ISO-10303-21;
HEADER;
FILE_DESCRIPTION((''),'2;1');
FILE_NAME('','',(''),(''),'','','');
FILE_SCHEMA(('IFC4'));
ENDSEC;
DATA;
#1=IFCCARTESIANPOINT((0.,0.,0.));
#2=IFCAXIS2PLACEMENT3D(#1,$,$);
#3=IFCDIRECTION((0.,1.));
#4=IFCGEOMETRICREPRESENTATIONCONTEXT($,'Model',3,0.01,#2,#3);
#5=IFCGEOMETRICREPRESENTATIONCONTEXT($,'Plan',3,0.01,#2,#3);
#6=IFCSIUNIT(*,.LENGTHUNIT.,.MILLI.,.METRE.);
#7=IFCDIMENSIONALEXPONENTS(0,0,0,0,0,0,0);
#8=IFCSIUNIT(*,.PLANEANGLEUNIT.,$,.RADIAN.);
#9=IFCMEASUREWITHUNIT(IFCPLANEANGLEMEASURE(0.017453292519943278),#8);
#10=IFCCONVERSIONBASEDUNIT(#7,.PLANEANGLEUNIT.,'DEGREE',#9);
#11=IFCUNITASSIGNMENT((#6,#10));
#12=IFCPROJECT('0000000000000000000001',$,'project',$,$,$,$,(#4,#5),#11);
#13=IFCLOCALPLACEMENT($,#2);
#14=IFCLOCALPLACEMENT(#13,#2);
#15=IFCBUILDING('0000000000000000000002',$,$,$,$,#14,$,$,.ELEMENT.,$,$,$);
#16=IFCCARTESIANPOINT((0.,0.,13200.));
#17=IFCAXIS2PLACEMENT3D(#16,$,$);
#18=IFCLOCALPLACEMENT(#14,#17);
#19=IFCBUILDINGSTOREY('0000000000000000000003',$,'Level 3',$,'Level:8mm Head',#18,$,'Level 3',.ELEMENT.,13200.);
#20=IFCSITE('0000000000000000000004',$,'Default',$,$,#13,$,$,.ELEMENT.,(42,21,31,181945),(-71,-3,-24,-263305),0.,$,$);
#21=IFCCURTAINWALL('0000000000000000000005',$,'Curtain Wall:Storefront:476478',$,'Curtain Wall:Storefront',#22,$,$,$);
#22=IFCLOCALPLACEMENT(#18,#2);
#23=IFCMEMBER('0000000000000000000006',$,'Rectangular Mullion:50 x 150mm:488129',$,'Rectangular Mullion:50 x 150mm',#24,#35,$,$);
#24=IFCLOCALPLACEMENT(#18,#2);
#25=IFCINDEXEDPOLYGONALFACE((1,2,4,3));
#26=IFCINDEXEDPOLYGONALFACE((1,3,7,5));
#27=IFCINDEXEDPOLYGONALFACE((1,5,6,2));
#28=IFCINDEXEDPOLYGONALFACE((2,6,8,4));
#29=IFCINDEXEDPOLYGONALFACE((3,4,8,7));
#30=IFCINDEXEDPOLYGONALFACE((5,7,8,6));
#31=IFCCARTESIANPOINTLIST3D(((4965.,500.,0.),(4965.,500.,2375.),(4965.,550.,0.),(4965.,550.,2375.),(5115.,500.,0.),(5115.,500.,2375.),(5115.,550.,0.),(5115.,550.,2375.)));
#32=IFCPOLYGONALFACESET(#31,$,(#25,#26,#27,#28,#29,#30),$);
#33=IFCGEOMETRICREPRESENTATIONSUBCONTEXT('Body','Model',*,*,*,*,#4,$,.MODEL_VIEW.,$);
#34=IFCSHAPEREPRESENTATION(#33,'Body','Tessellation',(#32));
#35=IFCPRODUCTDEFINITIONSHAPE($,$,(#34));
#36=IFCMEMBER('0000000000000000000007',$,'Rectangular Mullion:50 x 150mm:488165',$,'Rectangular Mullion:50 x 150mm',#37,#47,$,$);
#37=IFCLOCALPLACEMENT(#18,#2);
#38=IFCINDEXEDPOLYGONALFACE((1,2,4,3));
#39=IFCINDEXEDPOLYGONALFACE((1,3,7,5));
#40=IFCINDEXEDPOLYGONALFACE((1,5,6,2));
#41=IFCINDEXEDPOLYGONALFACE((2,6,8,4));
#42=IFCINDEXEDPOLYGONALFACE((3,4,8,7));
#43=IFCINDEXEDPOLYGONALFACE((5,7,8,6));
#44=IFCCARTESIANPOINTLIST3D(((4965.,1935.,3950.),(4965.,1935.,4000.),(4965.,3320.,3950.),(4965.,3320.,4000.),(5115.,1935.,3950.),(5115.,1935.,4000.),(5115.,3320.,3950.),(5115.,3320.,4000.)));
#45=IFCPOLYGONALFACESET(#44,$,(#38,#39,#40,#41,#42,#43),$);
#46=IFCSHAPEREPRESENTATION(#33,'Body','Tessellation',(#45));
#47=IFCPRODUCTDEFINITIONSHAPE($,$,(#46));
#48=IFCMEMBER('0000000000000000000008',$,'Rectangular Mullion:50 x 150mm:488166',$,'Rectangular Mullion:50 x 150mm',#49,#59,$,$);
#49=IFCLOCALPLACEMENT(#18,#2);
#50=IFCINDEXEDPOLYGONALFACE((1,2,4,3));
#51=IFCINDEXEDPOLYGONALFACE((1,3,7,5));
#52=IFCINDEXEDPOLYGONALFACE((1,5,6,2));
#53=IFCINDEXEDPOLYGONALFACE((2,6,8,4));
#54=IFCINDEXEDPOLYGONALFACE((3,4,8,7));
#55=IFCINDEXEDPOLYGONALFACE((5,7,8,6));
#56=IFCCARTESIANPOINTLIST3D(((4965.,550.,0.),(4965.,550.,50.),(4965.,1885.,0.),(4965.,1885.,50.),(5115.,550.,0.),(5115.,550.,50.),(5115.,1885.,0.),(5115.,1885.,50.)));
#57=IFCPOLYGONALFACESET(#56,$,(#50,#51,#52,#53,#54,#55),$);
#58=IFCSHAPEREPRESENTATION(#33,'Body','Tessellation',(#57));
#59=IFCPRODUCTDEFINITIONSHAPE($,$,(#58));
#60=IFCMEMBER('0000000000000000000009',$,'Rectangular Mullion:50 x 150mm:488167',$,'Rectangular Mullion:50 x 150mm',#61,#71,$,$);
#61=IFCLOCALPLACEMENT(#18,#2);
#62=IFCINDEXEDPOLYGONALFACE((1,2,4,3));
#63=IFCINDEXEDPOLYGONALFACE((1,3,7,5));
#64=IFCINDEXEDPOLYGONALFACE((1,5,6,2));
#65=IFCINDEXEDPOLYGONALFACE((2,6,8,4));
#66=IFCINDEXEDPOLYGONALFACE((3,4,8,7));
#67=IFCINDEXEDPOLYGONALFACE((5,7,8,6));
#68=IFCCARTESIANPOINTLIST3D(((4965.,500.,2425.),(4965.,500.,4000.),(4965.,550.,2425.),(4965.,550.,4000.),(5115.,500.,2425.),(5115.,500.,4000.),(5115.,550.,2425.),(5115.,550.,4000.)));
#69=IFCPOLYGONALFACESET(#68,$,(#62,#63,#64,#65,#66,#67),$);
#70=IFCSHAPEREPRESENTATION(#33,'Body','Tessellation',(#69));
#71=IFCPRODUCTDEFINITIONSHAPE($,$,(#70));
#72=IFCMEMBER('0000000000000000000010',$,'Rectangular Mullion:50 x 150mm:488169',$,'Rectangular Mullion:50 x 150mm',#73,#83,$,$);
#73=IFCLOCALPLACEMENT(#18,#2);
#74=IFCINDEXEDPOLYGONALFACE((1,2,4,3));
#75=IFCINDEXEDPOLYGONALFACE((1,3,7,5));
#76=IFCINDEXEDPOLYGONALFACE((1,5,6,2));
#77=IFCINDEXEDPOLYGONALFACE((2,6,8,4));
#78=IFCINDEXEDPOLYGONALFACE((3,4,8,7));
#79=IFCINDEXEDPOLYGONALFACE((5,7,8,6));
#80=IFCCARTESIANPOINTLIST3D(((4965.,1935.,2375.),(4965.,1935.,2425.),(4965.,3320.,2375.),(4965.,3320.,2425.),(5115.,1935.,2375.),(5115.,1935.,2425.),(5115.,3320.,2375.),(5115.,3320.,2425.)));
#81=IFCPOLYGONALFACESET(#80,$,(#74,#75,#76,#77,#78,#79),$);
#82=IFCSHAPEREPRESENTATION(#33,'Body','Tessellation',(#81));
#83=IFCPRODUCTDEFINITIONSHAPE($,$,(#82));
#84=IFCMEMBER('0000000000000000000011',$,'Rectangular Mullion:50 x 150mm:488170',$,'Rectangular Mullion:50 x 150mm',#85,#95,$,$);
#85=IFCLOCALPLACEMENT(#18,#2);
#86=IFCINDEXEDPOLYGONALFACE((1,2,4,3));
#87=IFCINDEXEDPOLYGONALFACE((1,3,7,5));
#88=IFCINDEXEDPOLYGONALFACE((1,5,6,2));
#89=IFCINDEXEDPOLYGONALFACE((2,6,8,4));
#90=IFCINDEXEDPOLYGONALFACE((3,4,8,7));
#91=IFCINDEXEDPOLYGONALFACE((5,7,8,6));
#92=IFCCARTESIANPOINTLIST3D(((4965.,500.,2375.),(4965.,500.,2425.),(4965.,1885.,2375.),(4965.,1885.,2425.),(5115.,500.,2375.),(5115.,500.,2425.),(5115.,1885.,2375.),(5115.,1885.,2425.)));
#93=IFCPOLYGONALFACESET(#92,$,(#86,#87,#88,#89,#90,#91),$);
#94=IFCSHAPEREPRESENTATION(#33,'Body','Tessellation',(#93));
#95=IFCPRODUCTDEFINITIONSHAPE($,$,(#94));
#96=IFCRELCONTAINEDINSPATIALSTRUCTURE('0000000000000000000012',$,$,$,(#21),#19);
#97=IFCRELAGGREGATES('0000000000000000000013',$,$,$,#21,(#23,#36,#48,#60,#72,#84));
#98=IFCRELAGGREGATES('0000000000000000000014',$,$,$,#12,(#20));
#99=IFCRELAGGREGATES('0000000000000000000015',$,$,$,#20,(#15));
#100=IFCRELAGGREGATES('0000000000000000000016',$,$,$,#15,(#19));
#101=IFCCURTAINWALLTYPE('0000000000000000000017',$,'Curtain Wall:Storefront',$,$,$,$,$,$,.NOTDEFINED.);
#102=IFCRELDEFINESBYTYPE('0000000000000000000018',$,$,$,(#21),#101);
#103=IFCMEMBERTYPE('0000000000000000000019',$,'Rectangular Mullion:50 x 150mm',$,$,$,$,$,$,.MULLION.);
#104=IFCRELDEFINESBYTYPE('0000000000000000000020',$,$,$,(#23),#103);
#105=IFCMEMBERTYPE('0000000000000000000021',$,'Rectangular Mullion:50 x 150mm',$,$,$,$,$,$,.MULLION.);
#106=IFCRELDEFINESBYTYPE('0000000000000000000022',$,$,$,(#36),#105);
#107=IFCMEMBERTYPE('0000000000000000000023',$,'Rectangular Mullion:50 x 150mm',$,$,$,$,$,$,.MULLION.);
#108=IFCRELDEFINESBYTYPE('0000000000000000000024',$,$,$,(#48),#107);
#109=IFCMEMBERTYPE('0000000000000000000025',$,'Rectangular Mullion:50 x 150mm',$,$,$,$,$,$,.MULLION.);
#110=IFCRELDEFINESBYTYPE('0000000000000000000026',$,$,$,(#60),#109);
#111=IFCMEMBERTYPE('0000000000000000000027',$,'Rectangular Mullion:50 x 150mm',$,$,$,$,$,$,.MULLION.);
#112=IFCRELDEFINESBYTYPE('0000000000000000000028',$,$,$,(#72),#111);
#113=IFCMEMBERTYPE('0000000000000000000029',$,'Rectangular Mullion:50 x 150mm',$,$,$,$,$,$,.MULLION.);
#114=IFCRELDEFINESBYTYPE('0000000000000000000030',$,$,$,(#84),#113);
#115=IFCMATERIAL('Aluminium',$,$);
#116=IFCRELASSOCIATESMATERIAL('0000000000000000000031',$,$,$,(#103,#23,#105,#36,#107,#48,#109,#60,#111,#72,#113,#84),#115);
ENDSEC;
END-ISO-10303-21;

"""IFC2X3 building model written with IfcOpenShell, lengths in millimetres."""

from ifc_helpers import new_model, entity, si_unit, converted_unit, direction, frame, origin, origin_2d_with_axis, place, context, subcontext, project, spatial, rectangle, extrude, source, transform, mapped, material, type_object, type_shapes, element, aggregate, save


model = new_model("IFC2X3")

# Units and contexts
model_context = context("Model", 3, precision=0.01, world=origin(), true_north=direction((0.0, 1.0)))
plan_context = context("Plan", 3, precision=0.01, world=origin(), true_north=direction((0.0, 1.0)))
body_context = subcontext(model_context, "Body", "Model", "MODEL_VIEW")
ifc_project = project(units=[si_unit("LENGTHUNIT", "METRE", prefix="MILLI"), converted_unit("PLANEANGLEUNIT", "DEGREE", entity("IfcPlaneAngleMeasure", 0.017453292519943278), si_unit("PLANEANGLEUNIT", "RADIAN"), dimensions=[0, 0, 0, 0, 0, 0, 0])], contexts=[model_context, plan_context])

# Site, building, storey
site_placement = place(None, origin())
site = spatial("IfcSite", under=ifc_project, at=site_placement, Name="Default", CompositionType="ELEMENT", RefLatitude=(42, 21, 31, 181945), RefLongitude=(-71, -3, -24, -263305), RefElevation=0.0)
building_placement = place(site_placement, origin())
building = spatial("IfcBuilding", under=site, at=building_placement, CompositionType="ELEMENT")
storey_placement = place(building_placement, frame((0.0, 0.0, 13200.0)))
storey = spatial("IfcBuildingStorey", under=building, at=storey_placement, Name="Level 3", ObjectType="Level:8mm Head", LongName="Level 3", CompositionType="ELEMENT", Elevation=13200.0)

# Curtain wall
curtain_wall_type = type_object("IfcCurtainWallType", Name="Curtain Wall:Storefront", PredefinedType="NOTDEFINED")
curtain_wall_1_placement = place(storey_placement, frame((0.0, 0.0, -13200.0)))
curtain_wall_1 = element("IfcCurtainWall", 1, at=curtain_wall_1_placement, inside=storey, type_object=curtain_wall_type, Name="Curtain Wall:Storefront:476478", ObjectType="Curtain Wall:Storefront")
ifc_material_1 = material(Name="Aluminium")

# Members
member_type_1 = type_object("IfcMemberType", Name="Rectangular Mullion:50 x 150mm", PredefinedType="MULLION", material=ifc_material_1)
shared_shape_1 = source(origin(), body_context, "Body", "SweptSolid", [
    extrude(rectangle(XDim=50.0, YDim=150.0, at=origin_2d_with_axis()), frame((-25.0, 0.0, -2375.0), z_axis=(0.0, 0.0, 1.0), x_axis=(-1.0, 0.0, 0.0)), (0.0, 0.0, 1.0), 2375.0),
])
type_shapes(member_type_1, [shared_shape_1])
member_1_placement = place(curtain_wall_1_placement, frame((5040.0, 500.0, 13200.0), z_axis=(0.0, 0.0, -1.0), x_axis=(0.0, -1.0, 0.0)))
member_1 = element("IfcMember", 2, at=member_1_placement, type_object=member_type_1, material=ifc_material_1, Name="Rectangular Mullion:50 x 150mm:488129", ObjectType="Rectangular Mullion:50 x 150mm", context=body_context, shape_type="MappedRepresentation", body=[
    mapped(shared_shape_1, transform((0.0, 0.0, 0.0), scale=1.0)),
])
member_type_2 = type_object("IfcMemberType", Name="Rectangular Mullion:50 x 150mm", PredefinedType="MULLION", material=ifc_material_1)
shared_shape_2 = source(origin(), body_context, "Body", "SweptSolid", [
    extrude(rectangle(XDim=50.0, YDim=150.0, at=origin_2d_with_axis()), frame((-25.0, 0.0, -1385.0), z_axis=(0.0, 0.0, 1.0), x_axis=(-1.0, 0.0, 0.0)), (0.0, 0.0, 1.0), 1385.0),
])
type_shapes(member_type_2, [shared_shape_2])
member_2_placement = place(curtain_wall_1_placement, frame((5040.0, 1935.0, 17200.0), z_axis=(0.0, -1.0, 0.0), x_axis=(0.0, 0.0, 1.0)))
member_2 = element("IfcMember", 3, at=member_2_placement, type_object=member_type_2, material=ifc_material_1, Name="Rectangular Mullion:50 x 150mm:488165", ObjectType="Rectangular Mullion:50 x 150mm", context=body_context, shape_type="MappedRepresentation", body=[
    mapped(shared_shape_2, transform((0.0, 0.0, 0.0), scale=1.0)),
])
member_type_3 = type_object("IfcMemberType", Name="Rectangular Mullion:50 x 150mm", PredefinedType="MULLION", material=ifc_material_1)
shared_shape_3 = source(origin(), body_context, "Body", "SweptSolid", [
    extrude(rectangle(XDim=50.0, YDim=150.0, at=origin_2d_with_axis()), frame((-25.0, 0.0, -1335.0), z_axis=(0.0, 0.0, 1.0), x_axis=(-1.0, 0.0, 0.0)), (0.0, 0.0, 1.0), 1335.0),
])
type_shapes(member_type_3, [shared_shape_3])
member_3_placement = place(curtain_wall_1_placement, frame((5040.0, 1885.0, 13200.0), z_axis=(0.0, 1.0, 0.0), x_axis=(0.0, 0.0, -1.0)))
member_3 = element("IfcMember", 4, at=member_3_placement, type_object=member_type_3, material=ifc_material_1, Name="Rectangular Mullion:50 x 150mm:488166", ObjectType="Rectangular Mullion:50 x 150mm", context=body_context, shape_type="MappedRepresentation", body=[
    mapped(shared_shape_3, transform((0.0, 0.0, 0.0), scale=1.0)),
])
member_type_4 = type_object("IfcMemberType", Name="Rectangular Mullion:50 x 150mm", PredefinedType="MULLION", material=ifc_material_1)
shared_shape_4 = source(origin(), body_context, "Body", "SweptSolid", [
    extrude(rectangle(XDim=50.0, YDim=150.0, at=origin_2d_with_axis()), frame((-25.0, 0.0, -1575.0), z_axis=(0.0, 0.0, 1.0), x_axis=(-1.0, 0.0, 0.0)), (0.0, 0.0, 1.0), 1575.0),
])
type_shapes(member_type_4, [shared_shape_4])
member_4_placement = place(curtain_wall_1_placement, frame((5040.0, 500.0, 15625.0), z_axis=(0.0, 0.0, -1.0), x_axis=(0.0, -1.0, 0.0)))
member_4 = element("IfcMember", 5, at=member_4_placement, type_object=member_type_4, material=ifc_material_1, Name="Rectangular Mullion:50 x 150mm:488167", ObjectType="Rectangular Mullion:50 x 150mm", context=body_context, shape_type="MappedRepresentation", body=[
    mapped(shared_shape_4, transform((0.0, 0.0, 0.0), scale=1.0)),
])
member_type_5 = type_object("IfcMemberType", Name="Rectangular Mullion:50 x 150mm", PredefinedType="MULLION", material=ifc_material_1)
shared_shape_5 = source(origin(), body_context, "Body", "SweptSolid", [
    extrude(rectangle(XDim=50.0, YDim=150.0, at=origin_2d_with_axis()), frame((0.0, 0.0, -1385.0), z_axis=(0.0, 0.0, 1.0), x_axis=(-1.0, 0.0, 0.0)), (0.0, 0.0, 1.0), 1385.0),
])
type_shapes(member_type_5, [shared_shape_5])
member_5_placement = place(curtain_wall_1_placement, frame((5040.0, 1935.0, 15600.0), z_axis=(0.0, -1.0, 0.0), x_axis=(0.0, 0.0, 1.0)))
member_5 = element("IfcMember", 6, at=member_5_placement, type_object=member_type_5, material=ifc_material_1, Name="Rectangular Mullion:50 x 150mm:488169", ObjectType="Rectangular Mullion:50 x 150mm", context=body_context, shape_type="MappedRepresentation", body=[
    mapped(shared_shape_5, transform((0.0, 0.0, 0.0), scale=1.0)),
])
member_type_6 = type_object("IfcMemberType", Name="Rectangular Mullion:50 x 150mm", PredefinedType="MULLION", material=ifc_material_1)
shared_shape_6 = source(origin(), body_context, "Body", "SweptSolid", [
    extrude(rectangle(XDim=50.0, YDim=150.0, at=origin_2d_with_axis()), frame((0.0, 0.0, -1385.0), z_axis=(0.0, 0.0, 1.0), x_axis=(-1.0, 0.0, 0.0)), (0.0, 0.0, 1.0), 1385.0),
])
type_shapes(member_type_6, [shared_shape_6])
member_6_placement = place(curtain_wall_1_placement, frame((5040.0, 500.0, 15600.0), z_axis=(0.0, -1.0, 0.0), x_axis=(0.0, 0.0, 1.0)))
member_6 = element("IfcMember", 7, at=member_6_placement, type_object=member_type_6, material=ifc_material_1, Name="Rectangular Mullion:50 x 150mm:488170", ObjectType="Rectangular Mullion:50 x 150mm", context=body_context, shape_type="MappedRepresentation", body=[
    mapped(shared_shape_6, transform((0.0, 0.0, 0.0), scale=1.0)),
])

aggregate(curtain_wall_1, [member_1, member_2, member_3, member_4, member_5, member_6])

save(model, "model.ifc")
